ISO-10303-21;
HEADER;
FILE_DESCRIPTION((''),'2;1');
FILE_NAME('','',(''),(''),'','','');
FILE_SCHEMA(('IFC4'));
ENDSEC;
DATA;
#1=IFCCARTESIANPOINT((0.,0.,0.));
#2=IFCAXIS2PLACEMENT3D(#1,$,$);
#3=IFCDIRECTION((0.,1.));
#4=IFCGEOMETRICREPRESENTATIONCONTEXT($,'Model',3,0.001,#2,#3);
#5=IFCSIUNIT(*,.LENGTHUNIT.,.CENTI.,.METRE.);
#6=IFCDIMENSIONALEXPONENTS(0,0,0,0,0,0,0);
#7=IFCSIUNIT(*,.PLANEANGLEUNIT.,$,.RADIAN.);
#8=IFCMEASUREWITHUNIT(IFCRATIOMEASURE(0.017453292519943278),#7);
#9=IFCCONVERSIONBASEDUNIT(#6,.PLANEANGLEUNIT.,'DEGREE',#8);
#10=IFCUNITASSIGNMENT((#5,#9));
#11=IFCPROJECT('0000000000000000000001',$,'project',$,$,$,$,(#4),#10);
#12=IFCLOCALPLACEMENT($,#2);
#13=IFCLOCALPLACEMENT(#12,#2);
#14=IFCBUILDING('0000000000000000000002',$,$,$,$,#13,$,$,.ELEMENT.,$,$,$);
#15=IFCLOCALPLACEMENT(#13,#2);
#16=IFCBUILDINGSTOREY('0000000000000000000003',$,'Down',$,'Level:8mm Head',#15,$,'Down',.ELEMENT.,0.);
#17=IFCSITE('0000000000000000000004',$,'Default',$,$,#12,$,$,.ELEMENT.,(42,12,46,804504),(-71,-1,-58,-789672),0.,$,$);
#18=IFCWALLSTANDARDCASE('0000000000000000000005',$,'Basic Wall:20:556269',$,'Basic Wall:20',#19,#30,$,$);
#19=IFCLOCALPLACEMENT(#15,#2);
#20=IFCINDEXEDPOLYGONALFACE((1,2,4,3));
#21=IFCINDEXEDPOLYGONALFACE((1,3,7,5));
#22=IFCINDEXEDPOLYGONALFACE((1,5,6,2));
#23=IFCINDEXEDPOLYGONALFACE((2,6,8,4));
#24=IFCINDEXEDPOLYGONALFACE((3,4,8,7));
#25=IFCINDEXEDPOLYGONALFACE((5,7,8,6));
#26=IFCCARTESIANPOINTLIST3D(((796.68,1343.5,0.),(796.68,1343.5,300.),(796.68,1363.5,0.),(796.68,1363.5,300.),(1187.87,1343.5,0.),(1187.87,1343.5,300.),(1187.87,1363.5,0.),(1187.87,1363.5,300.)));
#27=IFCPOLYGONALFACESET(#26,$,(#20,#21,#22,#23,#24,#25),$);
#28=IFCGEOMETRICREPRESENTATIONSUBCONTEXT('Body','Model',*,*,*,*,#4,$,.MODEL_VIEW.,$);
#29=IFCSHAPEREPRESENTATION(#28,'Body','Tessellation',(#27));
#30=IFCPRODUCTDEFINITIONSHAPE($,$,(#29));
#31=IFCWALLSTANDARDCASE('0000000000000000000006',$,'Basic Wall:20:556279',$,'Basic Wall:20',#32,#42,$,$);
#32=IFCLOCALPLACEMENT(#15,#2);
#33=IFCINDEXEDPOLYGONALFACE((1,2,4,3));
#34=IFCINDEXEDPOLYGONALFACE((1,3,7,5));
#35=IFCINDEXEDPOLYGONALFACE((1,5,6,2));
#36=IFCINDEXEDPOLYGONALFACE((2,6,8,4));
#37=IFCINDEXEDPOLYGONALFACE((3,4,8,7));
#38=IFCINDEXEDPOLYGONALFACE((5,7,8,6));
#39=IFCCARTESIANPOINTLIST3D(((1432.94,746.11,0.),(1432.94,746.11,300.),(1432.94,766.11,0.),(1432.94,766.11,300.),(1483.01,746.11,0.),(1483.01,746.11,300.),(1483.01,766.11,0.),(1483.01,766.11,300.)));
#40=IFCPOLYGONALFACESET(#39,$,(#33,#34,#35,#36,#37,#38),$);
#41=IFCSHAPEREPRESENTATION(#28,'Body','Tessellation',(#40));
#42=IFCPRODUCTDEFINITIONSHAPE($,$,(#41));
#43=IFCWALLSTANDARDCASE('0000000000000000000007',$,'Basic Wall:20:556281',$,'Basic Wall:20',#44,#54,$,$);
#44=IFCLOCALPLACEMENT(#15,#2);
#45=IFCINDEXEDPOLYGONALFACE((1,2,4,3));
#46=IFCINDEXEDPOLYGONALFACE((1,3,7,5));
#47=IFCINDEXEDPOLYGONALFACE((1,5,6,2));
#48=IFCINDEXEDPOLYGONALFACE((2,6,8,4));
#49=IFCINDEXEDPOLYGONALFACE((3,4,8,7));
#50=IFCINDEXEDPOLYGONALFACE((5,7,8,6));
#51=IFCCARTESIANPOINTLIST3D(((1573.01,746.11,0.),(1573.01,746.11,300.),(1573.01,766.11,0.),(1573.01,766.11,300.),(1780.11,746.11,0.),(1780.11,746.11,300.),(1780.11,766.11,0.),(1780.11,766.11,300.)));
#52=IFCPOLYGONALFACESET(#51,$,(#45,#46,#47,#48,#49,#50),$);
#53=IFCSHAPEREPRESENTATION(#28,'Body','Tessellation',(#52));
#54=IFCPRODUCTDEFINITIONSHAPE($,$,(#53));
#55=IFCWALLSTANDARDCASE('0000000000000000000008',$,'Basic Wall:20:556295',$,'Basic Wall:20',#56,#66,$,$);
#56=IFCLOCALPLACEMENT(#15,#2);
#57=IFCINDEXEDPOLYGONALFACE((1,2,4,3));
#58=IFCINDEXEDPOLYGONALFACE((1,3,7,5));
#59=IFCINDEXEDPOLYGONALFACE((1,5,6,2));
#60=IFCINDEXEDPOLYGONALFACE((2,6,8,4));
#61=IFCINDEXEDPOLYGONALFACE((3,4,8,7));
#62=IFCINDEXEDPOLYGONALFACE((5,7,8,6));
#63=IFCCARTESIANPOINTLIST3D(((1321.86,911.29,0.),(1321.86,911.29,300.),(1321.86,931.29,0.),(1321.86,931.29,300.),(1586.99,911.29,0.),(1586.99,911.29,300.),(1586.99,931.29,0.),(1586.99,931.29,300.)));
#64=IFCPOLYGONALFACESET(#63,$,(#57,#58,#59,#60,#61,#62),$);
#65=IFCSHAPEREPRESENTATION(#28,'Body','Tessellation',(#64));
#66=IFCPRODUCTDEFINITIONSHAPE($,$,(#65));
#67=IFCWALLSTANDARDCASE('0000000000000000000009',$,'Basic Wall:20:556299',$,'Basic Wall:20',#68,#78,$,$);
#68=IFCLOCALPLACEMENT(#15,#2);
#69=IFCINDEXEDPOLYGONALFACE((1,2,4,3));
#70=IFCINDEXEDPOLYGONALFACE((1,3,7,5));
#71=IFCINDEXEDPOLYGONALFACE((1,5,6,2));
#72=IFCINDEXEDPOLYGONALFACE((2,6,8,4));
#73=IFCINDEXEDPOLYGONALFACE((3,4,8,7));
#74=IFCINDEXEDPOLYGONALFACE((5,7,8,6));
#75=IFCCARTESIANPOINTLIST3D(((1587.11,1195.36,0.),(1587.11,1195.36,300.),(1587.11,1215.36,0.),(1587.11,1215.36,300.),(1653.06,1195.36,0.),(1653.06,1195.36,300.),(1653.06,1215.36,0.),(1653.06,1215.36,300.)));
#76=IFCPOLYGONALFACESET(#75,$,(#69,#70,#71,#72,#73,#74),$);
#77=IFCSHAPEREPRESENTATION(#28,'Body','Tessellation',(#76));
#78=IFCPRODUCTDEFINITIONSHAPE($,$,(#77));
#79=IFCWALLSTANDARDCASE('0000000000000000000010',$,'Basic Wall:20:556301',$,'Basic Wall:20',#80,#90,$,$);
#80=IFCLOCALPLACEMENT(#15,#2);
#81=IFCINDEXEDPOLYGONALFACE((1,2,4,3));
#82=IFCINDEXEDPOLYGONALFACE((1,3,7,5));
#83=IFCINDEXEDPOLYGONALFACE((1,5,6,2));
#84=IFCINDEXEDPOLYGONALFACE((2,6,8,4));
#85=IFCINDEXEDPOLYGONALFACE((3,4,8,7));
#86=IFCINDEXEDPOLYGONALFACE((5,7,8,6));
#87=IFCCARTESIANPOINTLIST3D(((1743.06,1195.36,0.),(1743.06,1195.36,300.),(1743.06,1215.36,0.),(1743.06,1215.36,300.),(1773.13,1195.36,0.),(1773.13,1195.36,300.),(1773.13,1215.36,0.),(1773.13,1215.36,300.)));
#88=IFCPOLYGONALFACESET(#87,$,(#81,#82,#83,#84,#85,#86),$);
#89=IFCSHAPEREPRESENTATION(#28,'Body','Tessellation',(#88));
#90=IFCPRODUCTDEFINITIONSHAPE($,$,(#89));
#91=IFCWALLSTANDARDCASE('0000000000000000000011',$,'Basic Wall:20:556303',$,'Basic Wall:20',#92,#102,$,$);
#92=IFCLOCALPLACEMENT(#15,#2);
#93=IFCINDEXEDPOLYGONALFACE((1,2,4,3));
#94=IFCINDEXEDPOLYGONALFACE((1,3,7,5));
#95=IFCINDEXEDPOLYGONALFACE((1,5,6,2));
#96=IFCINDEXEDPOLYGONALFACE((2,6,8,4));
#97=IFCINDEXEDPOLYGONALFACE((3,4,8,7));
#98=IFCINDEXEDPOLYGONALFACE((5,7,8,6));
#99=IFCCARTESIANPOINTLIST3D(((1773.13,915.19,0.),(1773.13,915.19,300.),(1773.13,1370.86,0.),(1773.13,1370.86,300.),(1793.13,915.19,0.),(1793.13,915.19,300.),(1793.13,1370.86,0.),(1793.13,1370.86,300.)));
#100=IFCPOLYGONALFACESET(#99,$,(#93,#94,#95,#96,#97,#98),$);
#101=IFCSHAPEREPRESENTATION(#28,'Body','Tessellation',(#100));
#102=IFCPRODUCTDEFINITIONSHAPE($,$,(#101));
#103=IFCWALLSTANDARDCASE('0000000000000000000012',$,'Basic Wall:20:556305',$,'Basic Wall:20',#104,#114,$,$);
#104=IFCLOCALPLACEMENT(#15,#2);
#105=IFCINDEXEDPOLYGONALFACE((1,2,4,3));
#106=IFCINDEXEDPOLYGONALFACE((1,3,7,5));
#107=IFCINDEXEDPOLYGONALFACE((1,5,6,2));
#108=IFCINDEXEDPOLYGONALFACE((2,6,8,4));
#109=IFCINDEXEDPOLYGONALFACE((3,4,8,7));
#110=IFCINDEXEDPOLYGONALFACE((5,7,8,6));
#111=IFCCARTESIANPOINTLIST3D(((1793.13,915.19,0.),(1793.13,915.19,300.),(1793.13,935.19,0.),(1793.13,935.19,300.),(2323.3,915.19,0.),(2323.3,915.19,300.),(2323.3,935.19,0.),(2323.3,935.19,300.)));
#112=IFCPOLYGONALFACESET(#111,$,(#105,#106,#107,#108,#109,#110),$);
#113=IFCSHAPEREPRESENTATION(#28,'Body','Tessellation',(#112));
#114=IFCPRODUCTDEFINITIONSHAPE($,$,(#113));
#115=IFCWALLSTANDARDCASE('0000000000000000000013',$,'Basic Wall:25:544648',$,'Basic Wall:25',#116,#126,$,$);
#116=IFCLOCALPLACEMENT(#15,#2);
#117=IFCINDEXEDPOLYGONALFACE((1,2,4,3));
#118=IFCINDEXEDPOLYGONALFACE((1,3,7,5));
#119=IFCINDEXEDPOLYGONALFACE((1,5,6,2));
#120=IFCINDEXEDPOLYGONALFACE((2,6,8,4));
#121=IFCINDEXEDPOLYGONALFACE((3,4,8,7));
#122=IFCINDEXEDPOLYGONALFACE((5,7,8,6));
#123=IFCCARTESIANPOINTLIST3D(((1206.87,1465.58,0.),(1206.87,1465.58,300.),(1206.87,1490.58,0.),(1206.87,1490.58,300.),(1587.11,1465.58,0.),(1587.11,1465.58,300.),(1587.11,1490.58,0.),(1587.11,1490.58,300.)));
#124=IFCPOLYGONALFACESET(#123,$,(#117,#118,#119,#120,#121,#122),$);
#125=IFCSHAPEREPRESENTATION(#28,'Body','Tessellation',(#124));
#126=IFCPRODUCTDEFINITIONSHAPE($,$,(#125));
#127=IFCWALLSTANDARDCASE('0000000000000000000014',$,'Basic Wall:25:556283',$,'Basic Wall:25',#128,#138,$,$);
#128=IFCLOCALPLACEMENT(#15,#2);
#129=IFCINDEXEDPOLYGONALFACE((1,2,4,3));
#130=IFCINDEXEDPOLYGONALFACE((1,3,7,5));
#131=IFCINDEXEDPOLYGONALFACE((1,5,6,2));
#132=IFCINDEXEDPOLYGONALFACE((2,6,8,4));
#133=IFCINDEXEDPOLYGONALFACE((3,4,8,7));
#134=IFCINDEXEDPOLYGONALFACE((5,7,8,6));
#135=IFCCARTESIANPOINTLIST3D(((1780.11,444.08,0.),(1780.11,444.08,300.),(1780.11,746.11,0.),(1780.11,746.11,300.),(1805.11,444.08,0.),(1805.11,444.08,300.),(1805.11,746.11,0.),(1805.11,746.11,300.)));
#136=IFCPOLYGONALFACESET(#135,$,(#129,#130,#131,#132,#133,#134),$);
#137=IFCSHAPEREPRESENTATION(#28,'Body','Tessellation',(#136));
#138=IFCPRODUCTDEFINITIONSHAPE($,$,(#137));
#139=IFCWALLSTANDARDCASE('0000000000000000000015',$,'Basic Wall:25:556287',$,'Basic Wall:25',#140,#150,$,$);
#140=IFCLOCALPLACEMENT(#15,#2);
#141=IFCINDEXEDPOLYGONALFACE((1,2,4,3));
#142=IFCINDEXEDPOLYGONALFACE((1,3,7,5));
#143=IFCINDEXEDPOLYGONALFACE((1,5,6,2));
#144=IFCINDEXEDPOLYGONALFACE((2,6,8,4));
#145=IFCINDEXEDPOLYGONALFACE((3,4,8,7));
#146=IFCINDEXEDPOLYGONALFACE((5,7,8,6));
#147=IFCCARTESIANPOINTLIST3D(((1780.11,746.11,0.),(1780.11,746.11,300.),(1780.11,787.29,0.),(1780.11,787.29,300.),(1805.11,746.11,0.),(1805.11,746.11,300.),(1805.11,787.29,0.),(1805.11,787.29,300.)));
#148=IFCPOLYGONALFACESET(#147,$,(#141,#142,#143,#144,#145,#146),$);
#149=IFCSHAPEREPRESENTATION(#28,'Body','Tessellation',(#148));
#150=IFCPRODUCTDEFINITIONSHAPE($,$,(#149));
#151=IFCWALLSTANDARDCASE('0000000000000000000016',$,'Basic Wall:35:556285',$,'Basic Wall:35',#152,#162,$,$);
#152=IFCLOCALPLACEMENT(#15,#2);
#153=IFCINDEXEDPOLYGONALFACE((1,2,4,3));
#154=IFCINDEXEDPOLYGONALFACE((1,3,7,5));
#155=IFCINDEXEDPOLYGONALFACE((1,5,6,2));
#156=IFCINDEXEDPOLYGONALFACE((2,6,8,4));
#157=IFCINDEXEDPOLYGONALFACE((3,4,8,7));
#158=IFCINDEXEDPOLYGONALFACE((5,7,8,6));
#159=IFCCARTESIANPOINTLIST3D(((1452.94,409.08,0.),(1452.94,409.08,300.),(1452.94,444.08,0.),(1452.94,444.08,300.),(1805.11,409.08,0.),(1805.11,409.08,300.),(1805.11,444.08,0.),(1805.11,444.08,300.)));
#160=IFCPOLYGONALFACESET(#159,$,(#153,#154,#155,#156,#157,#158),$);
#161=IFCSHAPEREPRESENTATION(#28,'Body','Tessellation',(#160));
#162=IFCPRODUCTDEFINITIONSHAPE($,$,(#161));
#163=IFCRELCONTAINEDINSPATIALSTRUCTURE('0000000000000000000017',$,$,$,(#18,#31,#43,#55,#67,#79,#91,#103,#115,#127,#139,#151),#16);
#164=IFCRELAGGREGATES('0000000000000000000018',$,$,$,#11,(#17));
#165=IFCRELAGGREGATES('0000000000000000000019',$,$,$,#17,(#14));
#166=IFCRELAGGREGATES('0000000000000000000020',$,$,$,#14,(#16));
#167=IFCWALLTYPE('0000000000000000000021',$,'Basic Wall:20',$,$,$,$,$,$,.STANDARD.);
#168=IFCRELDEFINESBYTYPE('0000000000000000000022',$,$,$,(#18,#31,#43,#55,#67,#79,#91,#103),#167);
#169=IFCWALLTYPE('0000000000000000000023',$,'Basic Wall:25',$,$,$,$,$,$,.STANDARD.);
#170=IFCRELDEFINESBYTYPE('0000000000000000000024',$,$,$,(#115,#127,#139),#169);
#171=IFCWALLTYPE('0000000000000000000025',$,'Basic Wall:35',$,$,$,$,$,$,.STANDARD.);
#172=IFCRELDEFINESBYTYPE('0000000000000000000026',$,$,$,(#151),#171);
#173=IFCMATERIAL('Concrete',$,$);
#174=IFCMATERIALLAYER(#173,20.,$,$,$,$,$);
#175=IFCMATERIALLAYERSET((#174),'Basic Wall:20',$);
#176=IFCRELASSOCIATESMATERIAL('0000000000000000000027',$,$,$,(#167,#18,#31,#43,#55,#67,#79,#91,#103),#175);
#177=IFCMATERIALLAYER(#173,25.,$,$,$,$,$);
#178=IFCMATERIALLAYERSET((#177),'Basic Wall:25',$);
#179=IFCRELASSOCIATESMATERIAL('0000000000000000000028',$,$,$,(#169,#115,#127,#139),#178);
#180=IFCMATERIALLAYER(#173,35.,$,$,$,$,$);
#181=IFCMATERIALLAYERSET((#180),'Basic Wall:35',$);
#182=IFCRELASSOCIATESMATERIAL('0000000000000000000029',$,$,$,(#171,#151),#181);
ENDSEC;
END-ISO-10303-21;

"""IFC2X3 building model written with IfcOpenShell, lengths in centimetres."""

from ifc_helpers import new_model, entity, si_unit, converted_unit, direction, frame, frame_2d, origin, place, context, subcontext, project, spatial, rectangle, extrude, material, layer, layer_set, layer_usage, type_object, element, save


model = new_model("IFC2X3")

# Units and contexts
model_context = context("Model", 3, precision=0.001, world=origin(), true_north=direction((0.0, 1.0)))
body_context = subcontext(model_context, "Body", "Model", "MODEL_VIEW")
ifc_project = project(units=[si_unit("LENGTHUNIT", "METRE", prefix="CENTI"), converted_unit("PLANEANGLEUNIT", "DEGREE", entity("IfcRatioMeasure", 0.017453292519943278), si_unit("PLANEANGLEUNIT", "RADIAN"), dimensions=[0, 0, 0, 0, 0, 0, 0])], contexts=[model_context])

# Site, building, storey
site_placement = place(None, origin())
site = spatial("IfcSite", under=ifc_project, at=site_placement, Name="Default", CompositionType="ELEMENT", RefLatitude=(42, 12, 46, 804504), RefLongitude=(-71, -1, -58, -789672), RefElevation=0.0)
building_placement = place(site_placement, origin())
building = spatial("IfcBuilding", under=site, at=building_placement, CompositionType="ELEMENT")
storey_placement = place(building_placement, origin())
storey = spatial("IfcBuildingStorey", under=building, at=storey_placement, Name="Down", ObjectType="Level:8mm Head", LongName="Down", CompositionType="ELEMENT", Elevation=0.0)

# Walls
ifc_material = material(Name="Concrete")
ifc_layer_1 = layer(ifc_material, 20.0)
ifc_layer_set_1 = layer_set([ifc_layer_1], Name="Basic Wall:20")
wall_type_1 = type_object("IfcWallType", Name="Basic Wall:20", PredefinedType="STANDARD", material=ifc_layer_set_1)
ifc_layer_usage_1 = layer_usage(ifc_layer_set_1, "AXIS2", "NEGATIVE", 10.0)
wall_1_placement = place(storey_placement, frame((796.68, 1353.5, 0.0)))
element("IfcWallStandardCase", 1, at=wall_1_placement, inside=storey, type_object=wall_type_1, material=ifc_layer_usage_1, Name="Basic Wall:20:556269", ObjectType="Basic Wall:20", context=body_context, shape_type="SweptSolid", body=[
    extrude(rectangle(XDim=391.19, YDim=20.0, at=frame_2d((195.6, 0.0), x_axis=(-1.0, 0.0))), origin(), (0.0, 0.0, 1.0), 300.0),
])
ifc_layer_usage_2 = layer_usage(ifc_layer_set_1, "AXIS2", "NEGATIVE", 10.0)
wall_2_placement = place(storey_placement, frame((1432.94, 756.11, 0.0)))
element("IfcWallStandardCase", 2, at=wall_2_placement, inside=storey, type_object=wall_type_1, material=ifc_layer_usage_2, Name="Basic Wall:20:556279", ObjectType="Basic Wall:20", context=body_context, shape_type="SweptSolid", body=[
    extrude(rectangle(XDim=50.07, YDim=20.0, at=frame_2d((25.04, 0.0), x_axis=(-1.0, 0.0))), origin(), (0.0, 0.0, 1.0), 300.0),
])
ifc_layer_usage_3 = layer_usage(ifc_layer_set_1, "AXIS2", "NEGATIVE", 10.0)
wall_3_placement = place(storey_placement, frame((1573.01, 756.11, 0.0)))
element("IfcWallStandardCase", 3, at=wall_3_placement, inside=storey, type_object=wall_type_1, material=ifc_layer_usage_3, Name="Basic Wall:20:556281", ObjectType="Basic Wall:20", context=body_context, shape_type="SweptSolid", body=[
    extrude(rectangle(XDim=207.1, YDim=20.0, at=frame_2d((103.55, 0.0), x_axis=(-1.0, 0.0))), origin(), (0.0, 0.0, 1.0), 300.0),
])
ifc_layer_usage_4 = layer_usage(ifc_layer_set_1, "AXIS2", "NEGATIVE", 10.0)
wall_4_placement = place(storey_placement, frame((1321.86, 921.29, 0.0)))
element("IfcWallStandardCase", 4, at=wall_4_placement, inside=storey, type_object=wall_type_1, material=ifc_layer_usage_4, Name="Basic Wall:20:556295", ObjectType="Basic Wall:20", context=body_context, shape_type="SweptSolid", body=[
    extrude(rectangle(XDim=265.13, YDim=20.0, at=frame_2d((132.57, 0.0), x_axis=(-1.0, 0.0))), origin(), (0.0, 0.0, 1.0), 300.0),
])
ifc_layer_usage_5 = layer_usage(ifc_layer_set_1, "AXIS2", "POSITIVE", -10.0)
wall_5_placement = place(storey_placement, frame((1587.11, 1205.36, 0.0)))
element("IfcWallStandardCase", 5, at=wall_5_placement, inside=storey, type_object=wall_type_1, material=ifc_layer_usage_5, Name="Basic Wall:20:556299", ObjectType="Basic Wall:20", context=body_context, shape_type="SweptSolid", body=[
    extrude(rectangle(XDim=65.95, YDim=20.0, at=frame_2d((32.98, 0.0), x_axis=(-1.0, 0.0))), origin(), (0.0, 0.0, 1.0), 300.0),
])
ifc_layer_usage_6 = layer_usage(ifc_layer_set_1, "AXIS2", "POSITIVE", -10.0)
wall_6_placement = place(storey_placement, frame((1743.06, 1205.36, 0.0)))
element("IfcWallStandardCase", 6, at=wall_6_placement, inside=storey, type_object=wall_type_1, material=ifc_layer_usage_6, Name="Basic Wall:20:556301", ObjectType="Basic Wall:20", context=body_context, shape_type="SweptSolid", body=[
    extrude(rectangle(XDim=30.07, YDim=20.0, at=frame_2d((15.04, 0.0), x_axis=(-1.0, 0.0))), origin(), (0.0, 0.0, 1.0), 300.0),
])
ifc_layer_usage_7 = layer_usage(ifc_layer_set_1, "AXIS2", "POSITIVE", -10.0)
wall_7_placement = place(storey_placement, frame((1783.13, 1370.86, 0.0), z_axis=(0.0, 0.0, 1.0), x_axis=(0.0, -1.0, 0.0)))
element("IfcWallStandardCase", 7, at=wall_7_placement, inside=storey, type_object=wall_type_1, material=ifc_layer_usage_7, Name="Basic Wall:20:556303", ObjectType="Basic Wall:20", context=body_context, shape_type="SweptSolid", body=[
    extrude(rectangle(XDim=455.67, YDim=20.0, at=frame_2d((227.83, 0.0), x_axis=(-1.0, 0.0))), origin(), (0.0, 0.0, 1.0), 300.0),
])
ifc_layer_usage_8 = layer_usage(ifc_layer_set_1, "AXIS2", "POSITIVE", -10.0)
wall_8_placement = place(storey_placement, frame((1793.13, 925.19, 0.0)))
element("IfcWallStandardCase", 8, at=wall_8_placement, inside=storey, type_object=wall_type_1, material=ifc_layer_usage_8, Name="Basic Wall:20:556305", ObjectType="Basic Wall:20", context=body_context, shape_type="SweptSolid", body=[
    extrude(rectangle(XDim=530.17, YDim=20.0, at=frame_2d((265.09, 0.0), x_axis=(-1.0, 0.0))), origin(), (0.0, 0.0, 1.0), 300.0),
])
ifc_layer_2 = layer(ifc_material, 25.0)
ifc_layer_set_2 = layer_set([ifc_layer_2], Name="Basic Wall:25")
ifc_layer_usage_9 = layer_usage(ifc_layer_set_2, "AXIS2", "NEGATIVE", 12.5)
wall_type_2 = type_object("IfcWallType", Name="Basic Wall:25", PredefinedType="STANDARD", material=ifc_layer_set_2)
wall_9_placement = place(storey_placement, frame((1206.87, 1478.08, 0.0)))
element("IfcWallStandardCase", 9, at=wall_9_placement, inside=storey, type_object=wall_type_2, material=ifc_layer_usage_9, Name="Basic Wall:25:544648", ObjectType="Basic Wall:25", context=body_context, shape_type="SweptSolid", body=[
    extrude(rectangle(XDim=380.24, YDim=25.0, at=frame_2d((190.12, 0.0), x_axis=(-1.0, 0.0))), origin(), (0.0, 0.0, 1.0), 300.0),
])
ifc_layer_usage_10 = layer_usage(ifc_layer_set_2, "AXIS2", "NEGATIVE", 12.5)
wall_10_placement = place(storey_placement, frame((1792.61, 746.11, 0.0), z_axis=(0.0, 0.0, 1.0), x_axis=(0.0, -1.0, 0.0)))
element("IfcWallStandardCase", 10, at=wall_10_placement, inside=storey, type_object=wall_type_2, material=ifc_layer_usage_10, Name="Basic Wall:25:556283", ObjectType="Basic Wall:25", context=body_context, shape_type="SweptSolid", body=[
    extrude(rectangle(XDim=302.03, YDim=25.0, at=frame_2d((151.01, 0.0), x_axis=(-1.0, 0.0))), origin(), (0.0, 0.0, 1.0), 300.0),
])
ifc_layer_usage_11 = layer_usage(ifc_layer_set_2, "AXIS2", "POSITIVE", -12.5)
wall_11_placement = place(storey_placement, frame((1792.61, 746.11, 0.0), z_axis=(0.0, 0.0, 1.0), x_axis=(0.0, 1.0, 0.0)))
element("IfcWallStandardCase", 11, at=wall_11_placement, inside=storey, type_object=wall_type_2, material=ifc_layer_usage_11, Name="Basic Wall:25:556287", ObjectType="Basic Wall:25", context=body_context, shape_type="SweptSolid", body=[
    extrude(rectangle(XDim=41.18, YDim=25.0, at=frame_2d((20.59, 0.0), x_axis=(-1.0, 0.0))), origin(), (0.0, 0.0, 1.0), 300.0),
])
ifc_layer_3 = layer(ifc_material, 35.0)
ifc_layer_set_3 = layer_set([ifc_layer_3], Name="Basic Wall:35")
ifc_layer_usage_12 = layer_usage(ifc_layer_set_3, "AXIS2", "NEGATIVE", 17.5)
wall_type_3 = type_object("IfcWallType", Name="Basic Wall:35", PredefinedType="STANDARD", material=ifc_layer_set_3)
wall_12_placement = place(storey_placement, frame((1805.11, 426.58, 0.0), z_axis=(0.0, 0.0, 1.0), x_axis=(-1.0, 0.0, 0.0)))
element("IfcWallStandardCase", 12, at=wall_12_placement, inside=storey, type_object=wall_type_3, material=ifc_layer_usage_12, Name="Basic Wall:35:556285", ObjectType="Basic Wall:35", context=body_context, shape_type="SweptSolid", body=[
    extrude(rectangle(XDim=352.17, YDim=35.0, at=frame_2d((176.08, 0.0), x_axis=(-1.0, 0.0))), origin(), (0.0, 0.0, 1.0), 300.0),
])

save(model, "model.ifc")
